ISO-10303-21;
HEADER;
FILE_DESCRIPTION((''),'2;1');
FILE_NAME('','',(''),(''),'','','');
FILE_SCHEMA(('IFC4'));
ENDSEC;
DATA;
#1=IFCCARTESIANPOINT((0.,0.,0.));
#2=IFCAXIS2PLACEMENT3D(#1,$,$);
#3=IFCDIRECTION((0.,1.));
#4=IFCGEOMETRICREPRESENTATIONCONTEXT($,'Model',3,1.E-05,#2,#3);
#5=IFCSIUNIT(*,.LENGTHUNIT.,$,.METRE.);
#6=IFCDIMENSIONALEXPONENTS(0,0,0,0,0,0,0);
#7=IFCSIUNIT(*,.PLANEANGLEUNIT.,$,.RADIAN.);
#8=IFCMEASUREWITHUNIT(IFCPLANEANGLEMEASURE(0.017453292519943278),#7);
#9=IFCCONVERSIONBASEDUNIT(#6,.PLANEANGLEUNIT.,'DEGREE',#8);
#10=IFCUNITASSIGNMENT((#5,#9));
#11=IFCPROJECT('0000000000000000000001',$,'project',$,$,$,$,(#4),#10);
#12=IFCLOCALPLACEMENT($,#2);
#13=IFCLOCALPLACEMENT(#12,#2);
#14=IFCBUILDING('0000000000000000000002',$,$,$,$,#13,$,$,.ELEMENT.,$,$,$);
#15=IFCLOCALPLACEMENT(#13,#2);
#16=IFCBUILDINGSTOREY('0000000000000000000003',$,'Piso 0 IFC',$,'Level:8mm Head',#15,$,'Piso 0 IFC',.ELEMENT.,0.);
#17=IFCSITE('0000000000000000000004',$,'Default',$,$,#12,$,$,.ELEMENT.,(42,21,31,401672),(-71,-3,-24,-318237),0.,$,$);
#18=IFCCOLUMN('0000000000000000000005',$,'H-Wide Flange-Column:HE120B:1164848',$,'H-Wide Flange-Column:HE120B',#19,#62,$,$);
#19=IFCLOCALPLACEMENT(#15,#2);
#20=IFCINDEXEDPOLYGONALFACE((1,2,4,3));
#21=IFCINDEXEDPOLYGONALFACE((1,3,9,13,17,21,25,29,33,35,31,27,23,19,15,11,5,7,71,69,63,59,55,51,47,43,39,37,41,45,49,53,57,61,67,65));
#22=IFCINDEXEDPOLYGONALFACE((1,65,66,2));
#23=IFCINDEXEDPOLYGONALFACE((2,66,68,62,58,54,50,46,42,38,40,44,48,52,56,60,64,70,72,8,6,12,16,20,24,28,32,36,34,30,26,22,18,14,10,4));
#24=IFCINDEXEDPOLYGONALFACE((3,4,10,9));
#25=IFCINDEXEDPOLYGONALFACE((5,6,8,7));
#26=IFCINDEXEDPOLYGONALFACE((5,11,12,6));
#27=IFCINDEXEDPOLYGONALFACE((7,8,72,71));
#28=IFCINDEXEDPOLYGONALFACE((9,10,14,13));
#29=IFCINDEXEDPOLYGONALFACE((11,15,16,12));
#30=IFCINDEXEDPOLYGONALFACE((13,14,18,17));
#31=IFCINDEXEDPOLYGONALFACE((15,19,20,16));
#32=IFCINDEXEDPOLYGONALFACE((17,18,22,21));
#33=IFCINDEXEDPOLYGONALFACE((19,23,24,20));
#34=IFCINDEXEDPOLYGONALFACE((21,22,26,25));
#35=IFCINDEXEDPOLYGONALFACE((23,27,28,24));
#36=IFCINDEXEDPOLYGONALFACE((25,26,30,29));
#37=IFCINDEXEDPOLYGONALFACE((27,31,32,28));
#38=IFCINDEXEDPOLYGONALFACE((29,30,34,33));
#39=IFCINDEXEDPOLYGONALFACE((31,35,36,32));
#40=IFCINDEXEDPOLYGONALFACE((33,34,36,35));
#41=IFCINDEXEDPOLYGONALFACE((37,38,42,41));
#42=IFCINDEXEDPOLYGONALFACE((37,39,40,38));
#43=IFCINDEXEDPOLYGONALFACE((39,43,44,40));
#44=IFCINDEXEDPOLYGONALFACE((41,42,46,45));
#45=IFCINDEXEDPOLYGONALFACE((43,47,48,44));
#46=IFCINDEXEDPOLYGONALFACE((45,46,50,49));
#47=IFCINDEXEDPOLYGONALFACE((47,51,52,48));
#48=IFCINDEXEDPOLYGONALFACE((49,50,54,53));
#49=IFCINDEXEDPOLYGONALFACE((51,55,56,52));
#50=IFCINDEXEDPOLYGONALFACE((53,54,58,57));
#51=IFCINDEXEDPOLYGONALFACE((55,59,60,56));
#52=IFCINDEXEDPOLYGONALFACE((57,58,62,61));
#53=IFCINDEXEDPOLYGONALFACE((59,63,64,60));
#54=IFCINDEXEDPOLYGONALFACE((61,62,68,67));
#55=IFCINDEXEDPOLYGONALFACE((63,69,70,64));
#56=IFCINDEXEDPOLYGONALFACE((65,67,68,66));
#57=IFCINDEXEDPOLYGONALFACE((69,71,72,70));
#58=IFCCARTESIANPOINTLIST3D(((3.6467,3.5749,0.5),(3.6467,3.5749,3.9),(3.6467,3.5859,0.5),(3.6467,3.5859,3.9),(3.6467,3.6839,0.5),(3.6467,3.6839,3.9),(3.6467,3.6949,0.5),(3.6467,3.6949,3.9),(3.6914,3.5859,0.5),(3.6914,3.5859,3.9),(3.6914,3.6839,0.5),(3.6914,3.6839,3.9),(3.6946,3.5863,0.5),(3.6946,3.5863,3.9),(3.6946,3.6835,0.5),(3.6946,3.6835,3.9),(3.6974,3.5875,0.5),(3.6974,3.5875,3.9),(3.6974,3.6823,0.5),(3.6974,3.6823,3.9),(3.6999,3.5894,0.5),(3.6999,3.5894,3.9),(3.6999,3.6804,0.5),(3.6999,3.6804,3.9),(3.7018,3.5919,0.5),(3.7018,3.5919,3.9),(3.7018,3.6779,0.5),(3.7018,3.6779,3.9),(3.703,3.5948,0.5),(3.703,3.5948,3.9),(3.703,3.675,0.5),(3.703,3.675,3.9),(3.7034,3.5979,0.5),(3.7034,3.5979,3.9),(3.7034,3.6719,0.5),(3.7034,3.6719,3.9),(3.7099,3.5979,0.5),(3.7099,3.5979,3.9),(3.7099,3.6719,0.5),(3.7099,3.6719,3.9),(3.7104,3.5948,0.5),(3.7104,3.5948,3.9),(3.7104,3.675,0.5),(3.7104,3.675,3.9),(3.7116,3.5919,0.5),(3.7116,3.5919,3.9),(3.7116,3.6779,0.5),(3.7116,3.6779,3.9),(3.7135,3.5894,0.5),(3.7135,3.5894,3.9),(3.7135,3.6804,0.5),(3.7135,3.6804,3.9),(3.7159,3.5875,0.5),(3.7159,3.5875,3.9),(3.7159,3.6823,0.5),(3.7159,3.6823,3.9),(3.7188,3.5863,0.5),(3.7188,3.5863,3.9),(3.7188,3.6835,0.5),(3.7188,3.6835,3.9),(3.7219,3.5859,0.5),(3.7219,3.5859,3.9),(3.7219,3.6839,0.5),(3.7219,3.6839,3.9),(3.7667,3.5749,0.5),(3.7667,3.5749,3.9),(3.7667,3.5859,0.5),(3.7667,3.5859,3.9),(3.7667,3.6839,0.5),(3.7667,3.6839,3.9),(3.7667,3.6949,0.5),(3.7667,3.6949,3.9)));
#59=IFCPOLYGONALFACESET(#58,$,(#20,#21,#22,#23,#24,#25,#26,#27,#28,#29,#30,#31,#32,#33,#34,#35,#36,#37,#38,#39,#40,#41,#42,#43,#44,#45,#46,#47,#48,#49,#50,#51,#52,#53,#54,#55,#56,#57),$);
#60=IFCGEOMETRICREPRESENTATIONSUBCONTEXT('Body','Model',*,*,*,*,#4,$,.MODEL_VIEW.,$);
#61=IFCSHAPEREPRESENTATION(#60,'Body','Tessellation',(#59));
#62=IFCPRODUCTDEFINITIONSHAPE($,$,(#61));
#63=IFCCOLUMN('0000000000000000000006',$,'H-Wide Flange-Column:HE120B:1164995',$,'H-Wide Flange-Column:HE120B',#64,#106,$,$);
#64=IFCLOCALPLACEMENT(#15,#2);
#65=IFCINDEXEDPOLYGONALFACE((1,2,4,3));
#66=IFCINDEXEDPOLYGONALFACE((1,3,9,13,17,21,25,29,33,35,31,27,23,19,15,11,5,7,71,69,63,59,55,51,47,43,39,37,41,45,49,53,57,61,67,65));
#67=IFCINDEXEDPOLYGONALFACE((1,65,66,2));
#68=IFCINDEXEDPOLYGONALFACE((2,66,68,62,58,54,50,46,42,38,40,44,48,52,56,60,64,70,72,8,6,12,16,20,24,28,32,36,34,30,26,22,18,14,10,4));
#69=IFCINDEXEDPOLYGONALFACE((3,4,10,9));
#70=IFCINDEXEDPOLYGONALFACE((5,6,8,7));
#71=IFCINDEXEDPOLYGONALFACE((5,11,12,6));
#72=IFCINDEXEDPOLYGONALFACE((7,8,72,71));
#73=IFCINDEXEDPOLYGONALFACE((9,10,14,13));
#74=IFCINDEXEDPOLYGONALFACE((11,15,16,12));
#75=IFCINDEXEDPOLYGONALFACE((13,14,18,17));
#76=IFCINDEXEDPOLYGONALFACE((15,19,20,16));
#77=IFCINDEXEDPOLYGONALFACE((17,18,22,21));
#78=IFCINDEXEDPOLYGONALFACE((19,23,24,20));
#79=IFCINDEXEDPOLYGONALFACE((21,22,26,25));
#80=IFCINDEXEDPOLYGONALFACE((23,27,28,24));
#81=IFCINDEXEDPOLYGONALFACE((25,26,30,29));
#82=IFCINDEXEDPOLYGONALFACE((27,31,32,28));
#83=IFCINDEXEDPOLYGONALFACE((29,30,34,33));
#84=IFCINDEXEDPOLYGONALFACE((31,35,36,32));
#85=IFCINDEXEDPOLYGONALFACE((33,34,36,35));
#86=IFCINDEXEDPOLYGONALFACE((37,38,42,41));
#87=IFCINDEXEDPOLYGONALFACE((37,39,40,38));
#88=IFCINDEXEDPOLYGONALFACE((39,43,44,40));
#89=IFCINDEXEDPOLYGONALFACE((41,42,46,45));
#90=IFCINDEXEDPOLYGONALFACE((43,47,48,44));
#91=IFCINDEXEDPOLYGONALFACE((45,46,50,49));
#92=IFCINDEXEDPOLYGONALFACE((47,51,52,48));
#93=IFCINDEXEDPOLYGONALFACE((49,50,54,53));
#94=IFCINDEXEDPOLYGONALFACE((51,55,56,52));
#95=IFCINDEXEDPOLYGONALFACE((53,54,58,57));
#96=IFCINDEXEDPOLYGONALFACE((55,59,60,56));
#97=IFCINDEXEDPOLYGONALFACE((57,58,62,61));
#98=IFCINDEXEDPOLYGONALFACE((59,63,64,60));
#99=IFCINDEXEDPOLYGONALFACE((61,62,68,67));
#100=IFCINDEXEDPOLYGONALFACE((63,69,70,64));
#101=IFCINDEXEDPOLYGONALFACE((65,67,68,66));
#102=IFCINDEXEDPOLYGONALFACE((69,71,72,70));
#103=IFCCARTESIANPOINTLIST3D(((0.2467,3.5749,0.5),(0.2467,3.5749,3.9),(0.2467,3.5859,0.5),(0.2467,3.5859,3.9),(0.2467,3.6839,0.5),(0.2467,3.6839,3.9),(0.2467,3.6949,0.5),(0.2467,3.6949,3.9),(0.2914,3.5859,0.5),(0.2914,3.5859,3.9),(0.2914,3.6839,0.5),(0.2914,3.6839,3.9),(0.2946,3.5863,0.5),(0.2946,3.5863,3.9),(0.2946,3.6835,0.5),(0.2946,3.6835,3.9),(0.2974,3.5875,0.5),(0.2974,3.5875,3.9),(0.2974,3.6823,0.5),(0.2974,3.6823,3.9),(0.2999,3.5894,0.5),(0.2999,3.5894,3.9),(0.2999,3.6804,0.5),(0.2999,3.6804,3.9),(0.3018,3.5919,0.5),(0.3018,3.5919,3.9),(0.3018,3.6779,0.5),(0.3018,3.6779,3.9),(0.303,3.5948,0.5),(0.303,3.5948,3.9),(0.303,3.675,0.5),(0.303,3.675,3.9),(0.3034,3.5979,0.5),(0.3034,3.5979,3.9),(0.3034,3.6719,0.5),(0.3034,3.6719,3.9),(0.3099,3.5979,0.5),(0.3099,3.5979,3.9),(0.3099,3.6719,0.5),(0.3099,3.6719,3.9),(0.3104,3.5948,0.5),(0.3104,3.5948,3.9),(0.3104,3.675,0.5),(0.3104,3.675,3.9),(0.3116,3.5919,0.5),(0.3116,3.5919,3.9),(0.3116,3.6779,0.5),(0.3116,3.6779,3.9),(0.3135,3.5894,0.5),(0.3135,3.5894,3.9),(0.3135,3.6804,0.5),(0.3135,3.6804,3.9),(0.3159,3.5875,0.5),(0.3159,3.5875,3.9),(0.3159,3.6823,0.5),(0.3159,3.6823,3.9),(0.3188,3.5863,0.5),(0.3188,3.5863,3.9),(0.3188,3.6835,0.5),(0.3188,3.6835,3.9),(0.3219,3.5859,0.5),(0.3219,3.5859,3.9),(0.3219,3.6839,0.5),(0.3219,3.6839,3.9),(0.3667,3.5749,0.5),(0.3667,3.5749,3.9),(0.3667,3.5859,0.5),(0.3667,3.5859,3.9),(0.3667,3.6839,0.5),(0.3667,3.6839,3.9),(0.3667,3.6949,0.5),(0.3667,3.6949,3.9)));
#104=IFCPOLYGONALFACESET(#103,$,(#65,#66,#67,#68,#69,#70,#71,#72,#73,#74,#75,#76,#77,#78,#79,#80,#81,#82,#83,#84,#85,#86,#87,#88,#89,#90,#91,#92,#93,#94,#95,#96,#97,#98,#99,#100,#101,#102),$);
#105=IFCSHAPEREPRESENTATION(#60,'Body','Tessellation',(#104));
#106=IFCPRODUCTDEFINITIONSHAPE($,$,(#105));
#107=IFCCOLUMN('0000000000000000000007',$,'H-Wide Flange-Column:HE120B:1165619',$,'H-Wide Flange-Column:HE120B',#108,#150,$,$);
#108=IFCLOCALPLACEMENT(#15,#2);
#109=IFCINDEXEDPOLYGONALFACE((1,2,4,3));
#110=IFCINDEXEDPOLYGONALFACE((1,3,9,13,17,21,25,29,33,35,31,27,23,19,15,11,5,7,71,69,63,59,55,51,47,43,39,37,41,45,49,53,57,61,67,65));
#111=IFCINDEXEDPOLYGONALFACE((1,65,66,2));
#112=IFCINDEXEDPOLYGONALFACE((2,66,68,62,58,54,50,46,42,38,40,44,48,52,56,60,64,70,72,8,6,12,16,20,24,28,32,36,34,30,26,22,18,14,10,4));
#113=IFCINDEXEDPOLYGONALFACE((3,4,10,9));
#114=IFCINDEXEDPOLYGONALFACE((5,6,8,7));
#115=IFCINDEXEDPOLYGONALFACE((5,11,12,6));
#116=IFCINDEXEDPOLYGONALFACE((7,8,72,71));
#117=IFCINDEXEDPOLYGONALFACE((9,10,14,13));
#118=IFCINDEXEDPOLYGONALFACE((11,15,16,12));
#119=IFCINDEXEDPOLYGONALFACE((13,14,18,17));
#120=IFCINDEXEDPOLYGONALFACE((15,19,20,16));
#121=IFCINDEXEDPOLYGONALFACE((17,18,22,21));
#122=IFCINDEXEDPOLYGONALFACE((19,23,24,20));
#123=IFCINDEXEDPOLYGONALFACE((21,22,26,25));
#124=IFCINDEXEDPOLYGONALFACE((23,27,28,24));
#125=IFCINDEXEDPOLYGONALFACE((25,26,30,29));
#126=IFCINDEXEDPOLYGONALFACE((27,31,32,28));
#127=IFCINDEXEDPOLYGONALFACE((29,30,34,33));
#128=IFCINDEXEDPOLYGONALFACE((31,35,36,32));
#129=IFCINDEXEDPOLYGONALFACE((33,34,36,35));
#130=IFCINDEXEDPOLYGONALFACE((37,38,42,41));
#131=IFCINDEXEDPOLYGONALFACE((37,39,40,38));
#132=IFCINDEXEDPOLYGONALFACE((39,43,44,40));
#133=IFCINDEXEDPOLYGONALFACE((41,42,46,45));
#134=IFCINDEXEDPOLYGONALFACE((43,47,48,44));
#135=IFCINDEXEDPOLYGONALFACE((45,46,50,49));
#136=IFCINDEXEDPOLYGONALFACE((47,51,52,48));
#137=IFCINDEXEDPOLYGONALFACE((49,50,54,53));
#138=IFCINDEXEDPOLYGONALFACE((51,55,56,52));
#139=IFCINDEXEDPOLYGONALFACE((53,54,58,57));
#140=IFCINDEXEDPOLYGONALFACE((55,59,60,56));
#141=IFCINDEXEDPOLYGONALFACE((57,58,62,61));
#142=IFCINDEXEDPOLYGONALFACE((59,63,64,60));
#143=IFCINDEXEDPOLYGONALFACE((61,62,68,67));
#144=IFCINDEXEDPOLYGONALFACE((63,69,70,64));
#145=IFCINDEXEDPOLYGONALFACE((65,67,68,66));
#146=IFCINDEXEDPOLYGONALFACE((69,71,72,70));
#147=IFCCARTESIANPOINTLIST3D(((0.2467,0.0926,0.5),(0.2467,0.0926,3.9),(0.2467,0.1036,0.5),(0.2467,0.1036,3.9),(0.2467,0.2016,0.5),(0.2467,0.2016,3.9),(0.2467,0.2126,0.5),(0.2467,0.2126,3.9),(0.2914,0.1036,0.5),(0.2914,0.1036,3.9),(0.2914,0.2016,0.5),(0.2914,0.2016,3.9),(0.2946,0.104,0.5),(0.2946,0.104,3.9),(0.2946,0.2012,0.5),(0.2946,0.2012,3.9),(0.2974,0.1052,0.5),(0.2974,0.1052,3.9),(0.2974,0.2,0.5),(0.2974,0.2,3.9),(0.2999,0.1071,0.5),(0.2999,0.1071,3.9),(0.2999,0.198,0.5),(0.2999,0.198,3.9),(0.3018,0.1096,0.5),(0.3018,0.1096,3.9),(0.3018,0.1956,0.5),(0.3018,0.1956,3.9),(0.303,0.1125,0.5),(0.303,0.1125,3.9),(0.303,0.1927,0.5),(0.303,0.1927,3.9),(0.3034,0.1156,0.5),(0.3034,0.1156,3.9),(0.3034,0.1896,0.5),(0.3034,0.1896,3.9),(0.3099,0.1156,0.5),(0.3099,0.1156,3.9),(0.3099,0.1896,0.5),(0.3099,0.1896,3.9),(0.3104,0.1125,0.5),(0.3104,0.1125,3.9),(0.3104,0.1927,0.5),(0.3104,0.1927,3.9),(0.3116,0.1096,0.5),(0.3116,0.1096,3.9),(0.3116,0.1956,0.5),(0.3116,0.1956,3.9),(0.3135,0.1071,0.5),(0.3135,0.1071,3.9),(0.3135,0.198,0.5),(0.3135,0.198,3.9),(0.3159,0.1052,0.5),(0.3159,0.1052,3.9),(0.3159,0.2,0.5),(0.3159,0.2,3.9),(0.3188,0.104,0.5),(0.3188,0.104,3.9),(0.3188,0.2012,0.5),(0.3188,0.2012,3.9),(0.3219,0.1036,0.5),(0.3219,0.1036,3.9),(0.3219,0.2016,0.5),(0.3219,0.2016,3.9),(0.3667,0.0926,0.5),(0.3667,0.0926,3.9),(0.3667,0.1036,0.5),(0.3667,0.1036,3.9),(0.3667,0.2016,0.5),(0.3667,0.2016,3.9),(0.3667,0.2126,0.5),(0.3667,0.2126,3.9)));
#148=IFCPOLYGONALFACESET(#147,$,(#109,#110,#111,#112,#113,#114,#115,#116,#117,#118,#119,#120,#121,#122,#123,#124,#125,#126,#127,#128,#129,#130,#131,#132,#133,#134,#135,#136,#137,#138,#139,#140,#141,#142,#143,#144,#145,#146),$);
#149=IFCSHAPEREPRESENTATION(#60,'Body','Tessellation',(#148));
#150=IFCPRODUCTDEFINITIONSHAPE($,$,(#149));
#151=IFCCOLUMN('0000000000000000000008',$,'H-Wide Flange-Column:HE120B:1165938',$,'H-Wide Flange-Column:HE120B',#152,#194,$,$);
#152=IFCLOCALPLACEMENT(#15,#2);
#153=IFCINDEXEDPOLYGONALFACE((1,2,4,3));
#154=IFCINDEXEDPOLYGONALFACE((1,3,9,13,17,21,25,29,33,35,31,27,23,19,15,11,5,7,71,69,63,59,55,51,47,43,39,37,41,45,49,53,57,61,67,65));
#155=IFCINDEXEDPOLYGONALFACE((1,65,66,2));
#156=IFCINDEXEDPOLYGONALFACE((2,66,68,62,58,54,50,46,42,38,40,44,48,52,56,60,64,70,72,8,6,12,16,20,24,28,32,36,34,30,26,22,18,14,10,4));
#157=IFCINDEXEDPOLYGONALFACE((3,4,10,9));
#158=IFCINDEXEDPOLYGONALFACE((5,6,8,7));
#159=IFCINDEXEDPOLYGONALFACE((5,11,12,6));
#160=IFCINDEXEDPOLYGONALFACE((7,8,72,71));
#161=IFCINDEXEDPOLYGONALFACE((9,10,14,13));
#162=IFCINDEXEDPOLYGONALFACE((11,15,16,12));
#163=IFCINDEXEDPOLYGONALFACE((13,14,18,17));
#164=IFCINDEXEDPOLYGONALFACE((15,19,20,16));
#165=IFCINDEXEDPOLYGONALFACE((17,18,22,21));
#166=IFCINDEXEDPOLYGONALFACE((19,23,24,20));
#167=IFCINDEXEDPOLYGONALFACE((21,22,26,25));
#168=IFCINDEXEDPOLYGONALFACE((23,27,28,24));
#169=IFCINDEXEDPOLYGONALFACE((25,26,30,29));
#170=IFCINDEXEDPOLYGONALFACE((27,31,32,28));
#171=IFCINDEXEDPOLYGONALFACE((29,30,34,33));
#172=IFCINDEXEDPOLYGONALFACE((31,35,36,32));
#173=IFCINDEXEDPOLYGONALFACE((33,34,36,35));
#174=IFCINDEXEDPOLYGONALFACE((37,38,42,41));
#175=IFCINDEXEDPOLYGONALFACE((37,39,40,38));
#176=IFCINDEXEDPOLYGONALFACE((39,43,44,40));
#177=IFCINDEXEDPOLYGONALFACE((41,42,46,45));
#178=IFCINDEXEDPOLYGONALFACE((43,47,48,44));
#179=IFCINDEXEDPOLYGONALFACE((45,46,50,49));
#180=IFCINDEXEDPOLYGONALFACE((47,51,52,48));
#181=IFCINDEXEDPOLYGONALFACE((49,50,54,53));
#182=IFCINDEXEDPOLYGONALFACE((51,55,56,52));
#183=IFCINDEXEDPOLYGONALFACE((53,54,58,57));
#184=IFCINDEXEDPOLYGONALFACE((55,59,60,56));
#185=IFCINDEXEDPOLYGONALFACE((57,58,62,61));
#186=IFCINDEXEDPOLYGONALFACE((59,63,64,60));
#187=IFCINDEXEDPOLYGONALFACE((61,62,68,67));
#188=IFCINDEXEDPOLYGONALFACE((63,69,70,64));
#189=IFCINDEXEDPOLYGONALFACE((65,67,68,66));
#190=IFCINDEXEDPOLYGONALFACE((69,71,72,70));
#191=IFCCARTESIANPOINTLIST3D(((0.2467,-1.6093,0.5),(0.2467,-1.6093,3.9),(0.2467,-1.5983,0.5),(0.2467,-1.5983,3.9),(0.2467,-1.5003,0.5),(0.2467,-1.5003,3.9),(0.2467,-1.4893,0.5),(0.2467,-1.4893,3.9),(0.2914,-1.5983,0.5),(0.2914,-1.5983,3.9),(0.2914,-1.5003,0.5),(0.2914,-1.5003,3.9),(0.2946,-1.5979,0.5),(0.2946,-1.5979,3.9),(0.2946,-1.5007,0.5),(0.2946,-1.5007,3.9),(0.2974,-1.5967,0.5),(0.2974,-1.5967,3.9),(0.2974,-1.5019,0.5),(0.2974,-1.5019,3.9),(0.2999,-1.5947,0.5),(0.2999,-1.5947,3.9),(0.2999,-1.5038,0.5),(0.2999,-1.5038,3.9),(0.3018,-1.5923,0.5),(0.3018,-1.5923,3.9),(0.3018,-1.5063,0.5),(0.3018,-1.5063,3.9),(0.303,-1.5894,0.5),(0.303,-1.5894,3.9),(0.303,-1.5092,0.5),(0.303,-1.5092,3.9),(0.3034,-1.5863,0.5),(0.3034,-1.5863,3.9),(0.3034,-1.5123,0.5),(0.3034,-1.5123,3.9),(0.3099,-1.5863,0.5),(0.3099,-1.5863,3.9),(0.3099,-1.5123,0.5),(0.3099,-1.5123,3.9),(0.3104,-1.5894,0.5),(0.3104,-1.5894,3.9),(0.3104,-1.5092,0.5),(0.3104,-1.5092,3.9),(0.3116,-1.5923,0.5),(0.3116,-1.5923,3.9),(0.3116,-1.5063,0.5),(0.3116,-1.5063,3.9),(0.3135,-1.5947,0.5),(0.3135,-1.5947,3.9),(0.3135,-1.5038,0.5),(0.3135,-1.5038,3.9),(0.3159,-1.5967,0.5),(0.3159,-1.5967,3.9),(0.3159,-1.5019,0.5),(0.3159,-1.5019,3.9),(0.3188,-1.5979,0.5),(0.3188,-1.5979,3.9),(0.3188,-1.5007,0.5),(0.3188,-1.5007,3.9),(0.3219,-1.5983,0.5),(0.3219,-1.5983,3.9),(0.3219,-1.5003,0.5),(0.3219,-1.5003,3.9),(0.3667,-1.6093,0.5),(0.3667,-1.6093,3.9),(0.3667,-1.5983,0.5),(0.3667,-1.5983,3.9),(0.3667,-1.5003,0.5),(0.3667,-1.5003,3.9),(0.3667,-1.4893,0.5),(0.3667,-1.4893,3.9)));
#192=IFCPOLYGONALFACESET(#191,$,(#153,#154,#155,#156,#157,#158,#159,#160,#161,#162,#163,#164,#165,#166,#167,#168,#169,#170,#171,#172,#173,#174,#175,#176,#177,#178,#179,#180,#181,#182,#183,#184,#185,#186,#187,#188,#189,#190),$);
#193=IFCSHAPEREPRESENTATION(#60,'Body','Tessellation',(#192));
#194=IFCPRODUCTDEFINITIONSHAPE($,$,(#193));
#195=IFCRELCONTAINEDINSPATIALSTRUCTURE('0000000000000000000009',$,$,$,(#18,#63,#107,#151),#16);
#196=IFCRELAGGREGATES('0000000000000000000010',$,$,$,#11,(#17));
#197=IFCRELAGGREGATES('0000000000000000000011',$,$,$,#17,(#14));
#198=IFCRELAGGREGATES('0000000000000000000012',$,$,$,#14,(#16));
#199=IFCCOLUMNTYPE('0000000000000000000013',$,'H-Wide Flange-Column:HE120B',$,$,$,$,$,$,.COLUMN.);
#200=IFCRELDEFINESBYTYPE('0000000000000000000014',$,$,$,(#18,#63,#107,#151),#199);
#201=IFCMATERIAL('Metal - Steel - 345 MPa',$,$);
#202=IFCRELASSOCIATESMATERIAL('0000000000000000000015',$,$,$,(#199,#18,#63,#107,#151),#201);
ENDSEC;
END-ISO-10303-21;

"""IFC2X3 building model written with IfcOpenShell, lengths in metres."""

from ifc_helpers import new_model, entity, si_unit, converted_unit, direction, frame, frame_2d, origin, place, context, subcontext, project, spatial, i_section, extrude, source, transform, mapped, material, type_object, type_shapes, element, save


model = new_model("IFC2X3")

# Units and contexts
model_context = context("Model", 3, precision=1e-05, world=origin(), true_north=direction((0.0, 1.0)))
body_context = subcontext(model_context, "Body", "Model", "MODEL_VIEW")
ifc_project = project(units=[si_unit("LENGTHUNIT", "METRE"), converted_unit("PLANEANGLEUNIT", "DEGREE", entity("IfcPlaneAngleMeasure", 0.017453292519943278), si_unit("PLANEANGLEUNIT", "RADIAN"), dimensions=[0, 0, 0, 0, 0, 0, 0])], contexts=[model_context])

# Site, building, storey
site_placement = place(None, origin())
site = spatial("IfcSite", under=ifc_project, at=site_placement, Name="Default", CompositionType="ELEMENT", RefLatitude=(42, 21, 31, 401672), RefLongitude=(-71, -3, -24, -318237), RefElevation=0.0)
building_placement = place(site_placement, origin())
building = spatial("IfcBuilding", under=site, at=building_placement, CompositionType="ELEMENT")
storey_placement = place(building_placement, origin())
storey = spatial("IfcBuildingStorey", under=building, at=storey_placement, Name="Piso 0 IFC", ObjectType="Level:8mm Head", LongName="Piso 0 IFC", CompositionType="ELEMENT", Elevation=0.0)

# Columns
ifc_material_1 = material(Name="Metal - Steel - 345 MPa")
column_type_1 = type_object("IfcColumnType", Name="H-Wide Flange-Column:HE120B", PredefinedType="COLUMN", material=ifc_material_1)
shared_shape_1 = source(origin(), body_context, "Body", "SweptSolid", [
    extrude(i_section(OverallWidth=0.12, OverallDepth=0.12, WebThickness=0.0065, FlangeThickness=0.011, FilletRadius=0.012, at=frame_2d((0.0, 0.0), x_axis=(1.0, 0.0))), frame((0.0, 0.0, 0.5), z_axis=(0.0, 0.0, 1.0), x_axis=(-1.0, 0.0, 0.0)), (0.0, 0.0, 1.0), 3.4),
])
type_shapes(column_type_1, [shared_shape_1])
for number, where, name in (
    (1, (3.7067, 3.6349, 0.0), "H-Wide Flange-Column:HE120B:1164848"),
    (2, (0.3067, 3.6349, 0.0), "H-Wide Flange-Column:HE120B:1164995"),
    (3, (0.3067, 0.1526, 0.0), "H-Wide Flange-Column:HE120B:1165619"),
    (4, (0.3067, -1.5493, 0.0), "H-Wide Flange-Column:HE120B:1165938"),
):
    element("IfcColumn", number, at=place(storey_placement, frame(where)), inside=storey, type_object=column_type_1, material=ifc_material_1, Name=name, ObjectType="H-Wide Flange-Column:HE120B", context=body_context, shape_type="MappedRepresentation", body=[
        mapped(shared_shape_1, transform((0.0, 0.0, 0.0), scale=1.0)),
    ])

save(model, "model.ifc")
